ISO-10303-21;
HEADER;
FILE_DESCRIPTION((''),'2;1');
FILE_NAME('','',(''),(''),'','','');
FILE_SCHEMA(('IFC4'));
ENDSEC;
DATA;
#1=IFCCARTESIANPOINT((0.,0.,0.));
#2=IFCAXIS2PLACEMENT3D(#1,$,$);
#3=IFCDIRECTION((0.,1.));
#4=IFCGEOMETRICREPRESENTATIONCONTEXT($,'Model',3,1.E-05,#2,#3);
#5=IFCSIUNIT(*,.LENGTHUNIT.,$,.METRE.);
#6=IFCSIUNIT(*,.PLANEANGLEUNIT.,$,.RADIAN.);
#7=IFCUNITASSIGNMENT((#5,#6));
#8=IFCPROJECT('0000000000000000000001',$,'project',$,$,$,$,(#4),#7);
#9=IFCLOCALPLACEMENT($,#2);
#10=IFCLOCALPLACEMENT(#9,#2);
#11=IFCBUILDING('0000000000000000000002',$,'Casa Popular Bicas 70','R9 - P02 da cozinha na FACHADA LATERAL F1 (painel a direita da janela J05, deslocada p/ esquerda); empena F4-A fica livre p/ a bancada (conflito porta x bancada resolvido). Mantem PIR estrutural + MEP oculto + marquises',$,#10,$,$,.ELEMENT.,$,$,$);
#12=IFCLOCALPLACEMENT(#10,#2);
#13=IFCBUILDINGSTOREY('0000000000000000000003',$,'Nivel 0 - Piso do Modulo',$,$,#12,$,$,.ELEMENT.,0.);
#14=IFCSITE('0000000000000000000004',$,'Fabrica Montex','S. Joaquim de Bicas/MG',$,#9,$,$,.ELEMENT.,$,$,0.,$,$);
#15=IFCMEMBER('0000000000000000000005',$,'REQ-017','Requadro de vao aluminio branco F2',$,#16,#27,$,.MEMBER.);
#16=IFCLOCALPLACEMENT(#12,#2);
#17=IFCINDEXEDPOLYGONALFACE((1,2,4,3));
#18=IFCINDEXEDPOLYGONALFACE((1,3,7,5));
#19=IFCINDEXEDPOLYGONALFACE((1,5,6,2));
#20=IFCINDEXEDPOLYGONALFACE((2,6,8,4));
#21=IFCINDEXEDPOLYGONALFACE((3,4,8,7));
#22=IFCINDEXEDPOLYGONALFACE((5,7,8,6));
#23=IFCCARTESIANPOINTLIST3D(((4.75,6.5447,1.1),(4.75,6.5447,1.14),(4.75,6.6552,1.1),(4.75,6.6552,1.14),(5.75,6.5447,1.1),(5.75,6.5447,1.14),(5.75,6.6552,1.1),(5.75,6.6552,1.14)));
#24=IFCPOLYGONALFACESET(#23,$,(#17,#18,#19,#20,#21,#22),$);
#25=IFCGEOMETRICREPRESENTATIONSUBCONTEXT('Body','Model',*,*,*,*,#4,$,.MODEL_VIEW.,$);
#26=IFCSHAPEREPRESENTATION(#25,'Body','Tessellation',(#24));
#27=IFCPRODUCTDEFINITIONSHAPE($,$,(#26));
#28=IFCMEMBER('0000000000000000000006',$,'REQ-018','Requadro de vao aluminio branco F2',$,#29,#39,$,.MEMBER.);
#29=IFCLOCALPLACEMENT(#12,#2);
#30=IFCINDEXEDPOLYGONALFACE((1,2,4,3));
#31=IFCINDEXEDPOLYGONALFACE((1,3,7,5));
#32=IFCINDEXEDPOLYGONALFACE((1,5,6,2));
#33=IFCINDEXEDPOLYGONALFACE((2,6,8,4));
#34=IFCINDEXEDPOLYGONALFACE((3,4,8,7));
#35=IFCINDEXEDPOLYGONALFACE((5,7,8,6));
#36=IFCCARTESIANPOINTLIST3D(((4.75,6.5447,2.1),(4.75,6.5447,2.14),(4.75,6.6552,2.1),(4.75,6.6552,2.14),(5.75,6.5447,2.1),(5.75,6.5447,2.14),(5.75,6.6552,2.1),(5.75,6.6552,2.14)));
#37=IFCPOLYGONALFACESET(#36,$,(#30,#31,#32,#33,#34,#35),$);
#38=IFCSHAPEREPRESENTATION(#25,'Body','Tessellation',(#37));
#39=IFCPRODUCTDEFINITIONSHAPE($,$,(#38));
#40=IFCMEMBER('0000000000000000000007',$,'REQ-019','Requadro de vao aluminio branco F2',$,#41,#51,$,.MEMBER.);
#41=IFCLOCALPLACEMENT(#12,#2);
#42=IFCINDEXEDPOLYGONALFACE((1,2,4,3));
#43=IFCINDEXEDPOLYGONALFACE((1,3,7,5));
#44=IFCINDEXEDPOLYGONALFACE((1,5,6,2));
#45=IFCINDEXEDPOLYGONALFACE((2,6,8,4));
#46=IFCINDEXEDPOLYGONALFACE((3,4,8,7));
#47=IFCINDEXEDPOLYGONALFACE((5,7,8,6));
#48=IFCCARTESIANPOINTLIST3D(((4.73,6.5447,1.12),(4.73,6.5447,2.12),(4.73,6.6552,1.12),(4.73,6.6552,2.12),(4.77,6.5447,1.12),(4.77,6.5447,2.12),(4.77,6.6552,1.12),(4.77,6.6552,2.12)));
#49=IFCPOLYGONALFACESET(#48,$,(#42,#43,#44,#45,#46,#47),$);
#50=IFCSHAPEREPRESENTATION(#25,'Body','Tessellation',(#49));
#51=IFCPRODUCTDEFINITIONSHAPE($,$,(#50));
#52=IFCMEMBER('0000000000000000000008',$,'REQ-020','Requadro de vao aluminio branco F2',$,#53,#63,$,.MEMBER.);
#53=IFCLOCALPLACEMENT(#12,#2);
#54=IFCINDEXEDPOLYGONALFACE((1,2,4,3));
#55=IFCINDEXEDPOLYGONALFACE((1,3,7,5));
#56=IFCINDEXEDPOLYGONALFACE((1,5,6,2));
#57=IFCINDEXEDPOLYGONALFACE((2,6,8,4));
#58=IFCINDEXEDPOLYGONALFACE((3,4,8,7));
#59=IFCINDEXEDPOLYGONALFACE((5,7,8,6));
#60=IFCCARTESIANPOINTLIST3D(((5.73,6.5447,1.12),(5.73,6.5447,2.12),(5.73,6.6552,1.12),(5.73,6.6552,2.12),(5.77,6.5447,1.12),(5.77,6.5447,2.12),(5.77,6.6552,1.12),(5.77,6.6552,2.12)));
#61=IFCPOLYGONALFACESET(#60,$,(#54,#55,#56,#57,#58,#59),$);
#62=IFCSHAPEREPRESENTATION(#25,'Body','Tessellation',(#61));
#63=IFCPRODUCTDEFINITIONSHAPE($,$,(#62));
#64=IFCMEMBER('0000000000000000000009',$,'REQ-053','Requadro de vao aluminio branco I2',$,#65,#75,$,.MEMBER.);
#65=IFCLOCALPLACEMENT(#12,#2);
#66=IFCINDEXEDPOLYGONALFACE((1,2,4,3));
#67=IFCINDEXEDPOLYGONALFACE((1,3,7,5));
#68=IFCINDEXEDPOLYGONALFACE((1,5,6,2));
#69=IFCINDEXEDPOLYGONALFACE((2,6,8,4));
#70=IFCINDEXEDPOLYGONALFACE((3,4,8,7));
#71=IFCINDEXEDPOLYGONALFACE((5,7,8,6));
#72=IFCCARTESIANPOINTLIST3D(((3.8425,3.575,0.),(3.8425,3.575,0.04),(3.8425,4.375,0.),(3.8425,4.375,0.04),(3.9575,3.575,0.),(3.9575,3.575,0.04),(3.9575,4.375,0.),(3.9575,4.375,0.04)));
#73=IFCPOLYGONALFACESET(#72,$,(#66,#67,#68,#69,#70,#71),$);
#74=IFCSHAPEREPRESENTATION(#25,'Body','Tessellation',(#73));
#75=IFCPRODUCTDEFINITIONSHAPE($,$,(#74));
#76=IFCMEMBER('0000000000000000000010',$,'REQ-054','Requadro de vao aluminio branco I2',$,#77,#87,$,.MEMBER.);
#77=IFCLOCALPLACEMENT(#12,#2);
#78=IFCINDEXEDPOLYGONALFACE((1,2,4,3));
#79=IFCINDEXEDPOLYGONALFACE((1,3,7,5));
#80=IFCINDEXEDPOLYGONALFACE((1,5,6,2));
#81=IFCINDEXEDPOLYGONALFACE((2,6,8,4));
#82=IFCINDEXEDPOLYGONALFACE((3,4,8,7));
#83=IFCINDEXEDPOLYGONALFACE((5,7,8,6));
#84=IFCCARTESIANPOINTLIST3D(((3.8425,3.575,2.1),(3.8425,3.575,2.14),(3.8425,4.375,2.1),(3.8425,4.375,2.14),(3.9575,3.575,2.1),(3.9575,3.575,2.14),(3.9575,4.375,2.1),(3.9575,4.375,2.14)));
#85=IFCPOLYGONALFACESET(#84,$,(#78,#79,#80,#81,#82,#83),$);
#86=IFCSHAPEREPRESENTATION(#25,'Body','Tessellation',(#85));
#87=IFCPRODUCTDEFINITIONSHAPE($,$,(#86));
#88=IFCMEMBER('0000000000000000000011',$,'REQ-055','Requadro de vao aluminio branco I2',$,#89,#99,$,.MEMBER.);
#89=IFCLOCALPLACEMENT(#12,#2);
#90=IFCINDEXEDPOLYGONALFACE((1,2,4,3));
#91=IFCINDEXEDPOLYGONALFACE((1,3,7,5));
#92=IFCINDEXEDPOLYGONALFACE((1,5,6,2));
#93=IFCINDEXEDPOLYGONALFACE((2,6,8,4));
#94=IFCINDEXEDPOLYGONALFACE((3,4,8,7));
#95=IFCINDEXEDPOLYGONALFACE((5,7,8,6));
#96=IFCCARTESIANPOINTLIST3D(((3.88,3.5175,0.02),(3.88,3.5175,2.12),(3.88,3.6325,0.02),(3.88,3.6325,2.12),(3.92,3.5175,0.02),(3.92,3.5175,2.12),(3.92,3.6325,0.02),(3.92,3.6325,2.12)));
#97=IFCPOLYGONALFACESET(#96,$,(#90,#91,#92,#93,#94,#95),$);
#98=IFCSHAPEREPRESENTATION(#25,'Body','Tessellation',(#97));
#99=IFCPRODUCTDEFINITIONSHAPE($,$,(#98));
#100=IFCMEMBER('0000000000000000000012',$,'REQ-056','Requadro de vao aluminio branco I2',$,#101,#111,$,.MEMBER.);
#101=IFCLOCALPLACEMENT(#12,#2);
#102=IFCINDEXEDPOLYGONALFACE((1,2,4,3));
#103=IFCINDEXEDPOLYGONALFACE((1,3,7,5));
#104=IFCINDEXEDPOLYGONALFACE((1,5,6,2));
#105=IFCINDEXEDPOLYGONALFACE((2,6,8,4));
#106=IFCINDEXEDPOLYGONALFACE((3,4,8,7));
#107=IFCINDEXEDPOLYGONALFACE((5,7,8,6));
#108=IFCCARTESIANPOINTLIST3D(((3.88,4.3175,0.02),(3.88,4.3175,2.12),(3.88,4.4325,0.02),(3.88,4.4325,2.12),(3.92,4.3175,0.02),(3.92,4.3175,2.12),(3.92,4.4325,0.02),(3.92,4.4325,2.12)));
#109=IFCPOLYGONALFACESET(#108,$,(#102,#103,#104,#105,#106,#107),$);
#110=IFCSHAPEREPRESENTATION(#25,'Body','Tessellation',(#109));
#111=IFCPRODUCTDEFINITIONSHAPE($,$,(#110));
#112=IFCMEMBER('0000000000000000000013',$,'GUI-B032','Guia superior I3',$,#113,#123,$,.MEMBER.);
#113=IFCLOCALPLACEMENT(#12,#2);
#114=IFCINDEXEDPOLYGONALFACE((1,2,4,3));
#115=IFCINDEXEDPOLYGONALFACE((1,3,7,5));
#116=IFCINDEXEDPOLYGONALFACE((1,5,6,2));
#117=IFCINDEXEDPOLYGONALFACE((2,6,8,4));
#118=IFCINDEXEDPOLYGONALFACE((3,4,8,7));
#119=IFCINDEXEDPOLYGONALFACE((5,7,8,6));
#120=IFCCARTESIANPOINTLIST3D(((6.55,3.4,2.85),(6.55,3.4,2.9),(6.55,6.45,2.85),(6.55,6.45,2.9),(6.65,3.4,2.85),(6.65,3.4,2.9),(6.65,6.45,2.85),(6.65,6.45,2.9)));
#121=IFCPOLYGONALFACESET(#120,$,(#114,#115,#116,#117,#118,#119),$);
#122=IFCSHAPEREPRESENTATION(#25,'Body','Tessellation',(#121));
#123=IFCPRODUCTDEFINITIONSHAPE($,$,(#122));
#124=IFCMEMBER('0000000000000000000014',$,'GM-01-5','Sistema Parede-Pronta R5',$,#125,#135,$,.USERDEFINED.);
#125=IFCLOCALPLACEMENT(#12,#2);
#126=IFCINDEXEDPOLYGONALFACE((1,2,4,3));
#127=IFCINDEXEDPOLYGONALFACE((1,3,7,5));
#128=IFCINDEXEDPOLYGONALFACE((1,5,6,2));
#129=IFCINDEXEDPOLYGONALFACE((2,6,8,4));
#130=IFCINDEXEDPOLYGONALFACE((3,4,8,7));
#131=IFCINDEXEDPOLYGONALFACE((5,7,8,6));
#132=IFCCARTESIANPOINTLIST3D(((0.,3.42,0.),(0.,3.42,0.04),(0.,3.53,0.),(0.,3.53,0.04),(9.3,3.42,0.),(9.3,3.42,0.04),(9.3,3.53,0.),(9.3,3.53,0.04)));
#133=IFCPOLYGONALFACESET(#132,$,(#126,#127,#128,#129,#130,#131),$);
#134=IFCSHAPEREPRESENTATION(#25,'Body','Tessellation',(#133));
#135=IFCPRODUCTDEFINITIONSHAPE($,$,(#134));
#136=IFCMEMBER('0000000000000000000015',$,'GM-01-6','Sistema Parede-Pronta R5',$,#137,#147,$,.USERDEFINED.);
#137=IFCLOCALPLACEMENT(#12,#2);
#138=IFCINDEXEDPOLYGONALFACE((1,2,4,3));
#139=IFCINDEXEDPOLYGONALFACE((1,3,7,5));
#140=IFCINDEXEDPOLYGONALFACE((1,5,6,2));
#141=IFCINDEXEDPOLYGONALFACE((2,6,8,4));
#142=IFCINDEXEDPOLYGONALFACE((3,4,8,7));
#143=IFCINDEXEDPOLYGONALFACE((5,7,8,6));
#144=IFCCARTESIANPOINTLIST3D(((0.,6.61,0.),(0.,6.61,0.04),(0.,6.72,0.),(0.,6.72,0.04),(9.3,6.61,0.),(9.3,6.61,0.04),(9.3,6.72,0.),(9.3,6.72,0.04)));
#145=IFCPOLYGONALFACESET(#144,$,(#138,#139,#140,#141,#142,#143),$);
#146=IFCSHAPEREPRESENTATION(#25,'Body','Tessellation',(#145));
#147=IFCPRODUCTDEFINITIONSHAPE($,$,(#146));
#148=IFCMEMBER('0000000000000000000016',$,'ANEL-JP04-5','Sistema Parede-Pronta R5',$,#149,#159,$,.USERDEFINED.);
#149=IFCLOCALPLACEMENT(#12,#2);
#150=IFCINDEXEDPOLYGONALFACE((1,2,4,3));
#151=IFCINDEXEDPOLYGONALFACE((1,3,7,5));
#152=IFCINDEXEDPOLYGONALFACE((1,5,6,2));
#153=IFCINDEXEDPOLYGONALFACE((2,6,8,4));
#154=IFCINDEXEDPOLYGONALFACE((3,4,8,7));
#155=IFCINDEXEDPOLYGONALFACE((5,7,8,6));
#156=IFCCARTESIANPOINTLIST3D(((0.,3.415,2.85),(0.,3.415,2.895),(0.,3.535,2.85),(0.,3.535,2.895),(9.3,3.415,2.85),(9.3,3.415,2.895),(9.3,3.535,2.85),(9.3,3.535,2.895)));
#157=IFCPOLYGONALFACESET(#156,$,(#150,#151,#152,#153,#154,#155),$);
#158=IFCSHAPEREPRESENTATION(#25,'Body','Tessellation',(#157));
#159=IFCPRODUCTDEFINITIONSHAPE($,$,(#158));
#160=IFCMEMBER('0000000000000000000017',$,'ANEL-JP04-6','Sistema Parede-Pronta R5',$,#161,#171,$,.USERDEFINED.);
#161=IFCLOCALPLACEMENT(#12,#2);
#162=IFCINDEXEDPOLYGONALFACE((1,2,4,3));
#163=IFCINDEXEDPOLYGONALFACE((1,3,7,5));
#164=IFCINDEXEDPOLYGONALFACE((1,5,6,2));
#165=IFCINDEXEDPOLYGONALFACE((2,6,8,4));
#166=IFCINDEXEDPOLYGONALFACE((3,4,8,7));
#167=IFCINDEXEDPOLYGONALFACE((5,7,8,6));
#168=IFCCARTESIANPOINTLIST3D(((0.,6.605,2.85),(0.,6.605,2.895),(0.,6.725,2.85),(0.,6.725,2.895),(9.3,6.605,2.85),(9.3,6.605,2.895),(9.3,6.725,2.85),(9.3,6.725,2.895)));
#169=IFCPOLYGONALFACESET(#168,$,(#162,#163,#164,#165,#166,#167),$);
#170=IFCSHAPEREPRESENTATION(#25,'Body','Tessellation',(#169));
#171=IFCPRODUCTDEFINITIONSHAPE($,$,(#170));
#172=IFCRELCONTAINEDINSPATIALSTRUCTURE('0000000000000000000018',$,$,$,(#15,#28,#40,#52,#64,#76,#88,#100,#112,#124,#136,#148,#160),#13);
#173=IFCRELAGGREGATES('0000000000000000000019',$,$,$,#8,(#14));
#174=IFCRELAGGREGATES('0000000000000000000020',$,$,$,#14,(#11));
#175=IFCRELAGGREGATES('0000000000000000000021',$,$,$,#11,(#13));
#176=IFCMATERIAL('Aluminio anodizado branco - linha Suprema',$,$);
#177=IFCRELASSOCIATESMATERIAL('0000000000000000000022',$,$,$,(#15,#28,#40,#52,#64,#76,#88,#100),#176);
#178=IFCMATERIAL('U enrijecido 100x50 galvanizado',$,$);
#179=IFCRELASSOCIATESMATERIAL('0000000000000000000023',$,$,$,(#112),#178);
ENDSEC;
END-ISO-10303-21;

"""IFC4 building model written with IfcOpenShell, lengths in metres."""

from ifc_helpers import new_model, si_unit, direction, frame, origin, origin_2d, place, context, subcontext, project, spatial, rectangle, extrude, material, element, save


model = new_model("IFC4")

# Units and contexts
model_context = context("Model", 3, precision=1e-05, world=origin(), true_north=direction((0.0, 1.0)))
body_context = subcontext(model_context, "Body", "Model", "MODEL_VIEW")
ifc_project = project(units=[si_unit("LENGTHUNIT", "METRE"), si_unit("PLANEANGLEUNIT", "RADIAN")], contexts=[model_context])

# Site, building, storey
site_placement = place(None, origin())
site = spatial("IfcSite", under=ifc_project, at=site_placement, Name="Fabrica Montex", Description="S. Joaquim de Bicas/MG", CompositionType="ELEMENT", RefElevation=0.0)
building_placement = place(site_placement, origin())
building = spatial("IfcBuilding", under=site, at=building_placement, Name="Casa Popular Bicas 70", Description="R9 - P02 da cozinha na FACHADA LATERAL F1 (painel a direita da janela J05, deslocada p/ esquerda); empena F4-A fica livre p/ a bancada (conflito porta x bancada resolvido). Mantem PIR estrutural + MEP oculto + marquises", CompositionType="ELEMENT")
storey_placement = place(building_placement, origin())
storey = spatial("IfcBuildingStorey", under=building, at=storey_placement, Name="Nivel 0 - Piso do Modulo", CompositionType="ELEMENT", Elevation=0.0)

# Members
ifc_material_1 = material(Name="Aluminio anodizado branco - linha Suprema")
for number, where, z_axis, x_axis, name in (
    (1, (4.75, 6.6, 1.12), (1.0, 0.0, 0.0), (0.0, 0.0, 1.0), "REQ-017"),
    (2, (4.75, 6.6, 2.12), (1.0, 0.0, 0.0), (0.0, 0.0, 1.0), "REQ-018"),
    (3, (4.75, 6.6, 1.12), (0.0, 0.0, 1.0), (1.0, 0.0, 0.0), "REQ-019"),
    (4, (5.75, 6.6, 1.12), (0.0, 0.0, 1.0), (1.0, 0.0, 0.0), "REQ-020"),
):
    element("IfcMember", number, at=place(storey_placement, frame(where, z_axis=z_axis, x_axis=x_axis)), inside=storey, material=ifc_material_1, Name=name, Description="Requadro de vao aluminio branco F2", PredefinedType="MEMBER", context=body_context, shape_type="SweptSolid", body=[
        extrude(rectangle(XDim=0.04, YDim=0.1105, at=origin_2d()), origin(), (0.0, 0.0, 1.0), 1.0),
    ])
for number, where, z_axis, x_axis, name in (
    (5, (3.9, 3.575, 0.02), (0.0, 1.0, 0.0), (0.0, 0.0, 1.0), "REQ-053"),
    (6, (3.9, 3.575, 2.12), (0.0, 1.0, 0.0), (0.0, 0.0, 1.0), "REQ-054"),
):
    element("IfcMember", number, at=place(storey_placement, frame(where, z_axis=z_axis, x_axis=x_axis)), inside=storey, material=ifc_material_1, Name=name, Description="Requadro de vao aluminio branco I2", PredefinedType="MEMBER", context=body_context, shape_type="SweptSolid", body=[
        extrude(rectangle(XDim=0.04, YDim=0.115, at=origin_2d()), origin(), (0.0, 0.0, 1.0), 0.8),
    ])
for number, where, z_axis, x_axis, name in (
    (7, (3.9, 3.575, 0.02), (0.0, 0.0, 1.0), (1.0, 0.0, 0.0), "REQ-055"),
    (8, (3.9, 4.375, 0.02), (0.0, 0.0, 1.0), (1.0, 0.0, 0.0), "REQ-056"),
):
    element("IfcMember", number, at=place(storey_placement, frame(where, z_axis=z_axis, x_axis=x_axis)), inside=storey, material=ifc_material_1, Name=name, Description="Requadro de vao aluminio branco I2", PredefinedType="MEMBER", context=body_context, shape_type="SweptSolid", body=[
        extrude(rectangle(XDim=0.04, YDim=0.115, at=origin_2d()), origin(), (0.0, 0.0, 1.0), 2.1),
    ])
ifc_material_2 = material(Name="U enrijecido 100x50 galvanizado")
member_placement = place(storey_placement, frame((6.6, 3.4, 2.875), z_axis=(0.0, 1.0, 0.0), x_axis=(0.0, 0.0, 1.0)))
element("IfcMember", 9, at=member_placement, inside=storey, material=ifc_material_2, Name="GUI-B032", Description="Guia superior I3", PredefinedType="MEMBER", context=body_context, shape_type="SweptSolid", body=[
    extrude(rectangle(XDim=0.05, YDim=0.1, at=origin_2d()), origin(), (0.0, 0.0, 1.0), 3.05),
])
for number, where, name in (
    (10, (4.65, 3.475, 0.0), "GM-01-5"),
    (11, (4.65, 6.665, 0.0), "GM-01-6"),
):
    element("IfcMember", number, at=place(storey_placement, frame(where)), inside=storey, Name=name, Description="Sistema Parede-Pronta R5", PredefinedType="USERDEFINED", context=body_context, shape_type="SweptSolid", body=[
        extrude(rectangle(XDim=9.3, YDim=0.11, at=origin_2d()), origin(), (0.0, 0.0, 1.0), 0.04),
    ])
for number, where, name in (
    (12, (4.65, 3.475, 2.85), "ANEL-JP04-5"),
    (13, (4.65, 6.665, 2.85), "ANEL-JP04-6"),
):
    element("IfcMember", number, at=place(storey_placement, frame(where)), inside=storey, Name=name, Description="Sistema Parede-Pronta R5", PredefinedType="USERDEFINED", context=body_context, shape_type="SweptSolid", body=[
        extrude(rectangle(XDim=9.3, YDim=0.12, at=origin_2d()), origin(), (0.0, 0.0, 1.0), 0.045),
    ])

save(model, "model.ifc")
